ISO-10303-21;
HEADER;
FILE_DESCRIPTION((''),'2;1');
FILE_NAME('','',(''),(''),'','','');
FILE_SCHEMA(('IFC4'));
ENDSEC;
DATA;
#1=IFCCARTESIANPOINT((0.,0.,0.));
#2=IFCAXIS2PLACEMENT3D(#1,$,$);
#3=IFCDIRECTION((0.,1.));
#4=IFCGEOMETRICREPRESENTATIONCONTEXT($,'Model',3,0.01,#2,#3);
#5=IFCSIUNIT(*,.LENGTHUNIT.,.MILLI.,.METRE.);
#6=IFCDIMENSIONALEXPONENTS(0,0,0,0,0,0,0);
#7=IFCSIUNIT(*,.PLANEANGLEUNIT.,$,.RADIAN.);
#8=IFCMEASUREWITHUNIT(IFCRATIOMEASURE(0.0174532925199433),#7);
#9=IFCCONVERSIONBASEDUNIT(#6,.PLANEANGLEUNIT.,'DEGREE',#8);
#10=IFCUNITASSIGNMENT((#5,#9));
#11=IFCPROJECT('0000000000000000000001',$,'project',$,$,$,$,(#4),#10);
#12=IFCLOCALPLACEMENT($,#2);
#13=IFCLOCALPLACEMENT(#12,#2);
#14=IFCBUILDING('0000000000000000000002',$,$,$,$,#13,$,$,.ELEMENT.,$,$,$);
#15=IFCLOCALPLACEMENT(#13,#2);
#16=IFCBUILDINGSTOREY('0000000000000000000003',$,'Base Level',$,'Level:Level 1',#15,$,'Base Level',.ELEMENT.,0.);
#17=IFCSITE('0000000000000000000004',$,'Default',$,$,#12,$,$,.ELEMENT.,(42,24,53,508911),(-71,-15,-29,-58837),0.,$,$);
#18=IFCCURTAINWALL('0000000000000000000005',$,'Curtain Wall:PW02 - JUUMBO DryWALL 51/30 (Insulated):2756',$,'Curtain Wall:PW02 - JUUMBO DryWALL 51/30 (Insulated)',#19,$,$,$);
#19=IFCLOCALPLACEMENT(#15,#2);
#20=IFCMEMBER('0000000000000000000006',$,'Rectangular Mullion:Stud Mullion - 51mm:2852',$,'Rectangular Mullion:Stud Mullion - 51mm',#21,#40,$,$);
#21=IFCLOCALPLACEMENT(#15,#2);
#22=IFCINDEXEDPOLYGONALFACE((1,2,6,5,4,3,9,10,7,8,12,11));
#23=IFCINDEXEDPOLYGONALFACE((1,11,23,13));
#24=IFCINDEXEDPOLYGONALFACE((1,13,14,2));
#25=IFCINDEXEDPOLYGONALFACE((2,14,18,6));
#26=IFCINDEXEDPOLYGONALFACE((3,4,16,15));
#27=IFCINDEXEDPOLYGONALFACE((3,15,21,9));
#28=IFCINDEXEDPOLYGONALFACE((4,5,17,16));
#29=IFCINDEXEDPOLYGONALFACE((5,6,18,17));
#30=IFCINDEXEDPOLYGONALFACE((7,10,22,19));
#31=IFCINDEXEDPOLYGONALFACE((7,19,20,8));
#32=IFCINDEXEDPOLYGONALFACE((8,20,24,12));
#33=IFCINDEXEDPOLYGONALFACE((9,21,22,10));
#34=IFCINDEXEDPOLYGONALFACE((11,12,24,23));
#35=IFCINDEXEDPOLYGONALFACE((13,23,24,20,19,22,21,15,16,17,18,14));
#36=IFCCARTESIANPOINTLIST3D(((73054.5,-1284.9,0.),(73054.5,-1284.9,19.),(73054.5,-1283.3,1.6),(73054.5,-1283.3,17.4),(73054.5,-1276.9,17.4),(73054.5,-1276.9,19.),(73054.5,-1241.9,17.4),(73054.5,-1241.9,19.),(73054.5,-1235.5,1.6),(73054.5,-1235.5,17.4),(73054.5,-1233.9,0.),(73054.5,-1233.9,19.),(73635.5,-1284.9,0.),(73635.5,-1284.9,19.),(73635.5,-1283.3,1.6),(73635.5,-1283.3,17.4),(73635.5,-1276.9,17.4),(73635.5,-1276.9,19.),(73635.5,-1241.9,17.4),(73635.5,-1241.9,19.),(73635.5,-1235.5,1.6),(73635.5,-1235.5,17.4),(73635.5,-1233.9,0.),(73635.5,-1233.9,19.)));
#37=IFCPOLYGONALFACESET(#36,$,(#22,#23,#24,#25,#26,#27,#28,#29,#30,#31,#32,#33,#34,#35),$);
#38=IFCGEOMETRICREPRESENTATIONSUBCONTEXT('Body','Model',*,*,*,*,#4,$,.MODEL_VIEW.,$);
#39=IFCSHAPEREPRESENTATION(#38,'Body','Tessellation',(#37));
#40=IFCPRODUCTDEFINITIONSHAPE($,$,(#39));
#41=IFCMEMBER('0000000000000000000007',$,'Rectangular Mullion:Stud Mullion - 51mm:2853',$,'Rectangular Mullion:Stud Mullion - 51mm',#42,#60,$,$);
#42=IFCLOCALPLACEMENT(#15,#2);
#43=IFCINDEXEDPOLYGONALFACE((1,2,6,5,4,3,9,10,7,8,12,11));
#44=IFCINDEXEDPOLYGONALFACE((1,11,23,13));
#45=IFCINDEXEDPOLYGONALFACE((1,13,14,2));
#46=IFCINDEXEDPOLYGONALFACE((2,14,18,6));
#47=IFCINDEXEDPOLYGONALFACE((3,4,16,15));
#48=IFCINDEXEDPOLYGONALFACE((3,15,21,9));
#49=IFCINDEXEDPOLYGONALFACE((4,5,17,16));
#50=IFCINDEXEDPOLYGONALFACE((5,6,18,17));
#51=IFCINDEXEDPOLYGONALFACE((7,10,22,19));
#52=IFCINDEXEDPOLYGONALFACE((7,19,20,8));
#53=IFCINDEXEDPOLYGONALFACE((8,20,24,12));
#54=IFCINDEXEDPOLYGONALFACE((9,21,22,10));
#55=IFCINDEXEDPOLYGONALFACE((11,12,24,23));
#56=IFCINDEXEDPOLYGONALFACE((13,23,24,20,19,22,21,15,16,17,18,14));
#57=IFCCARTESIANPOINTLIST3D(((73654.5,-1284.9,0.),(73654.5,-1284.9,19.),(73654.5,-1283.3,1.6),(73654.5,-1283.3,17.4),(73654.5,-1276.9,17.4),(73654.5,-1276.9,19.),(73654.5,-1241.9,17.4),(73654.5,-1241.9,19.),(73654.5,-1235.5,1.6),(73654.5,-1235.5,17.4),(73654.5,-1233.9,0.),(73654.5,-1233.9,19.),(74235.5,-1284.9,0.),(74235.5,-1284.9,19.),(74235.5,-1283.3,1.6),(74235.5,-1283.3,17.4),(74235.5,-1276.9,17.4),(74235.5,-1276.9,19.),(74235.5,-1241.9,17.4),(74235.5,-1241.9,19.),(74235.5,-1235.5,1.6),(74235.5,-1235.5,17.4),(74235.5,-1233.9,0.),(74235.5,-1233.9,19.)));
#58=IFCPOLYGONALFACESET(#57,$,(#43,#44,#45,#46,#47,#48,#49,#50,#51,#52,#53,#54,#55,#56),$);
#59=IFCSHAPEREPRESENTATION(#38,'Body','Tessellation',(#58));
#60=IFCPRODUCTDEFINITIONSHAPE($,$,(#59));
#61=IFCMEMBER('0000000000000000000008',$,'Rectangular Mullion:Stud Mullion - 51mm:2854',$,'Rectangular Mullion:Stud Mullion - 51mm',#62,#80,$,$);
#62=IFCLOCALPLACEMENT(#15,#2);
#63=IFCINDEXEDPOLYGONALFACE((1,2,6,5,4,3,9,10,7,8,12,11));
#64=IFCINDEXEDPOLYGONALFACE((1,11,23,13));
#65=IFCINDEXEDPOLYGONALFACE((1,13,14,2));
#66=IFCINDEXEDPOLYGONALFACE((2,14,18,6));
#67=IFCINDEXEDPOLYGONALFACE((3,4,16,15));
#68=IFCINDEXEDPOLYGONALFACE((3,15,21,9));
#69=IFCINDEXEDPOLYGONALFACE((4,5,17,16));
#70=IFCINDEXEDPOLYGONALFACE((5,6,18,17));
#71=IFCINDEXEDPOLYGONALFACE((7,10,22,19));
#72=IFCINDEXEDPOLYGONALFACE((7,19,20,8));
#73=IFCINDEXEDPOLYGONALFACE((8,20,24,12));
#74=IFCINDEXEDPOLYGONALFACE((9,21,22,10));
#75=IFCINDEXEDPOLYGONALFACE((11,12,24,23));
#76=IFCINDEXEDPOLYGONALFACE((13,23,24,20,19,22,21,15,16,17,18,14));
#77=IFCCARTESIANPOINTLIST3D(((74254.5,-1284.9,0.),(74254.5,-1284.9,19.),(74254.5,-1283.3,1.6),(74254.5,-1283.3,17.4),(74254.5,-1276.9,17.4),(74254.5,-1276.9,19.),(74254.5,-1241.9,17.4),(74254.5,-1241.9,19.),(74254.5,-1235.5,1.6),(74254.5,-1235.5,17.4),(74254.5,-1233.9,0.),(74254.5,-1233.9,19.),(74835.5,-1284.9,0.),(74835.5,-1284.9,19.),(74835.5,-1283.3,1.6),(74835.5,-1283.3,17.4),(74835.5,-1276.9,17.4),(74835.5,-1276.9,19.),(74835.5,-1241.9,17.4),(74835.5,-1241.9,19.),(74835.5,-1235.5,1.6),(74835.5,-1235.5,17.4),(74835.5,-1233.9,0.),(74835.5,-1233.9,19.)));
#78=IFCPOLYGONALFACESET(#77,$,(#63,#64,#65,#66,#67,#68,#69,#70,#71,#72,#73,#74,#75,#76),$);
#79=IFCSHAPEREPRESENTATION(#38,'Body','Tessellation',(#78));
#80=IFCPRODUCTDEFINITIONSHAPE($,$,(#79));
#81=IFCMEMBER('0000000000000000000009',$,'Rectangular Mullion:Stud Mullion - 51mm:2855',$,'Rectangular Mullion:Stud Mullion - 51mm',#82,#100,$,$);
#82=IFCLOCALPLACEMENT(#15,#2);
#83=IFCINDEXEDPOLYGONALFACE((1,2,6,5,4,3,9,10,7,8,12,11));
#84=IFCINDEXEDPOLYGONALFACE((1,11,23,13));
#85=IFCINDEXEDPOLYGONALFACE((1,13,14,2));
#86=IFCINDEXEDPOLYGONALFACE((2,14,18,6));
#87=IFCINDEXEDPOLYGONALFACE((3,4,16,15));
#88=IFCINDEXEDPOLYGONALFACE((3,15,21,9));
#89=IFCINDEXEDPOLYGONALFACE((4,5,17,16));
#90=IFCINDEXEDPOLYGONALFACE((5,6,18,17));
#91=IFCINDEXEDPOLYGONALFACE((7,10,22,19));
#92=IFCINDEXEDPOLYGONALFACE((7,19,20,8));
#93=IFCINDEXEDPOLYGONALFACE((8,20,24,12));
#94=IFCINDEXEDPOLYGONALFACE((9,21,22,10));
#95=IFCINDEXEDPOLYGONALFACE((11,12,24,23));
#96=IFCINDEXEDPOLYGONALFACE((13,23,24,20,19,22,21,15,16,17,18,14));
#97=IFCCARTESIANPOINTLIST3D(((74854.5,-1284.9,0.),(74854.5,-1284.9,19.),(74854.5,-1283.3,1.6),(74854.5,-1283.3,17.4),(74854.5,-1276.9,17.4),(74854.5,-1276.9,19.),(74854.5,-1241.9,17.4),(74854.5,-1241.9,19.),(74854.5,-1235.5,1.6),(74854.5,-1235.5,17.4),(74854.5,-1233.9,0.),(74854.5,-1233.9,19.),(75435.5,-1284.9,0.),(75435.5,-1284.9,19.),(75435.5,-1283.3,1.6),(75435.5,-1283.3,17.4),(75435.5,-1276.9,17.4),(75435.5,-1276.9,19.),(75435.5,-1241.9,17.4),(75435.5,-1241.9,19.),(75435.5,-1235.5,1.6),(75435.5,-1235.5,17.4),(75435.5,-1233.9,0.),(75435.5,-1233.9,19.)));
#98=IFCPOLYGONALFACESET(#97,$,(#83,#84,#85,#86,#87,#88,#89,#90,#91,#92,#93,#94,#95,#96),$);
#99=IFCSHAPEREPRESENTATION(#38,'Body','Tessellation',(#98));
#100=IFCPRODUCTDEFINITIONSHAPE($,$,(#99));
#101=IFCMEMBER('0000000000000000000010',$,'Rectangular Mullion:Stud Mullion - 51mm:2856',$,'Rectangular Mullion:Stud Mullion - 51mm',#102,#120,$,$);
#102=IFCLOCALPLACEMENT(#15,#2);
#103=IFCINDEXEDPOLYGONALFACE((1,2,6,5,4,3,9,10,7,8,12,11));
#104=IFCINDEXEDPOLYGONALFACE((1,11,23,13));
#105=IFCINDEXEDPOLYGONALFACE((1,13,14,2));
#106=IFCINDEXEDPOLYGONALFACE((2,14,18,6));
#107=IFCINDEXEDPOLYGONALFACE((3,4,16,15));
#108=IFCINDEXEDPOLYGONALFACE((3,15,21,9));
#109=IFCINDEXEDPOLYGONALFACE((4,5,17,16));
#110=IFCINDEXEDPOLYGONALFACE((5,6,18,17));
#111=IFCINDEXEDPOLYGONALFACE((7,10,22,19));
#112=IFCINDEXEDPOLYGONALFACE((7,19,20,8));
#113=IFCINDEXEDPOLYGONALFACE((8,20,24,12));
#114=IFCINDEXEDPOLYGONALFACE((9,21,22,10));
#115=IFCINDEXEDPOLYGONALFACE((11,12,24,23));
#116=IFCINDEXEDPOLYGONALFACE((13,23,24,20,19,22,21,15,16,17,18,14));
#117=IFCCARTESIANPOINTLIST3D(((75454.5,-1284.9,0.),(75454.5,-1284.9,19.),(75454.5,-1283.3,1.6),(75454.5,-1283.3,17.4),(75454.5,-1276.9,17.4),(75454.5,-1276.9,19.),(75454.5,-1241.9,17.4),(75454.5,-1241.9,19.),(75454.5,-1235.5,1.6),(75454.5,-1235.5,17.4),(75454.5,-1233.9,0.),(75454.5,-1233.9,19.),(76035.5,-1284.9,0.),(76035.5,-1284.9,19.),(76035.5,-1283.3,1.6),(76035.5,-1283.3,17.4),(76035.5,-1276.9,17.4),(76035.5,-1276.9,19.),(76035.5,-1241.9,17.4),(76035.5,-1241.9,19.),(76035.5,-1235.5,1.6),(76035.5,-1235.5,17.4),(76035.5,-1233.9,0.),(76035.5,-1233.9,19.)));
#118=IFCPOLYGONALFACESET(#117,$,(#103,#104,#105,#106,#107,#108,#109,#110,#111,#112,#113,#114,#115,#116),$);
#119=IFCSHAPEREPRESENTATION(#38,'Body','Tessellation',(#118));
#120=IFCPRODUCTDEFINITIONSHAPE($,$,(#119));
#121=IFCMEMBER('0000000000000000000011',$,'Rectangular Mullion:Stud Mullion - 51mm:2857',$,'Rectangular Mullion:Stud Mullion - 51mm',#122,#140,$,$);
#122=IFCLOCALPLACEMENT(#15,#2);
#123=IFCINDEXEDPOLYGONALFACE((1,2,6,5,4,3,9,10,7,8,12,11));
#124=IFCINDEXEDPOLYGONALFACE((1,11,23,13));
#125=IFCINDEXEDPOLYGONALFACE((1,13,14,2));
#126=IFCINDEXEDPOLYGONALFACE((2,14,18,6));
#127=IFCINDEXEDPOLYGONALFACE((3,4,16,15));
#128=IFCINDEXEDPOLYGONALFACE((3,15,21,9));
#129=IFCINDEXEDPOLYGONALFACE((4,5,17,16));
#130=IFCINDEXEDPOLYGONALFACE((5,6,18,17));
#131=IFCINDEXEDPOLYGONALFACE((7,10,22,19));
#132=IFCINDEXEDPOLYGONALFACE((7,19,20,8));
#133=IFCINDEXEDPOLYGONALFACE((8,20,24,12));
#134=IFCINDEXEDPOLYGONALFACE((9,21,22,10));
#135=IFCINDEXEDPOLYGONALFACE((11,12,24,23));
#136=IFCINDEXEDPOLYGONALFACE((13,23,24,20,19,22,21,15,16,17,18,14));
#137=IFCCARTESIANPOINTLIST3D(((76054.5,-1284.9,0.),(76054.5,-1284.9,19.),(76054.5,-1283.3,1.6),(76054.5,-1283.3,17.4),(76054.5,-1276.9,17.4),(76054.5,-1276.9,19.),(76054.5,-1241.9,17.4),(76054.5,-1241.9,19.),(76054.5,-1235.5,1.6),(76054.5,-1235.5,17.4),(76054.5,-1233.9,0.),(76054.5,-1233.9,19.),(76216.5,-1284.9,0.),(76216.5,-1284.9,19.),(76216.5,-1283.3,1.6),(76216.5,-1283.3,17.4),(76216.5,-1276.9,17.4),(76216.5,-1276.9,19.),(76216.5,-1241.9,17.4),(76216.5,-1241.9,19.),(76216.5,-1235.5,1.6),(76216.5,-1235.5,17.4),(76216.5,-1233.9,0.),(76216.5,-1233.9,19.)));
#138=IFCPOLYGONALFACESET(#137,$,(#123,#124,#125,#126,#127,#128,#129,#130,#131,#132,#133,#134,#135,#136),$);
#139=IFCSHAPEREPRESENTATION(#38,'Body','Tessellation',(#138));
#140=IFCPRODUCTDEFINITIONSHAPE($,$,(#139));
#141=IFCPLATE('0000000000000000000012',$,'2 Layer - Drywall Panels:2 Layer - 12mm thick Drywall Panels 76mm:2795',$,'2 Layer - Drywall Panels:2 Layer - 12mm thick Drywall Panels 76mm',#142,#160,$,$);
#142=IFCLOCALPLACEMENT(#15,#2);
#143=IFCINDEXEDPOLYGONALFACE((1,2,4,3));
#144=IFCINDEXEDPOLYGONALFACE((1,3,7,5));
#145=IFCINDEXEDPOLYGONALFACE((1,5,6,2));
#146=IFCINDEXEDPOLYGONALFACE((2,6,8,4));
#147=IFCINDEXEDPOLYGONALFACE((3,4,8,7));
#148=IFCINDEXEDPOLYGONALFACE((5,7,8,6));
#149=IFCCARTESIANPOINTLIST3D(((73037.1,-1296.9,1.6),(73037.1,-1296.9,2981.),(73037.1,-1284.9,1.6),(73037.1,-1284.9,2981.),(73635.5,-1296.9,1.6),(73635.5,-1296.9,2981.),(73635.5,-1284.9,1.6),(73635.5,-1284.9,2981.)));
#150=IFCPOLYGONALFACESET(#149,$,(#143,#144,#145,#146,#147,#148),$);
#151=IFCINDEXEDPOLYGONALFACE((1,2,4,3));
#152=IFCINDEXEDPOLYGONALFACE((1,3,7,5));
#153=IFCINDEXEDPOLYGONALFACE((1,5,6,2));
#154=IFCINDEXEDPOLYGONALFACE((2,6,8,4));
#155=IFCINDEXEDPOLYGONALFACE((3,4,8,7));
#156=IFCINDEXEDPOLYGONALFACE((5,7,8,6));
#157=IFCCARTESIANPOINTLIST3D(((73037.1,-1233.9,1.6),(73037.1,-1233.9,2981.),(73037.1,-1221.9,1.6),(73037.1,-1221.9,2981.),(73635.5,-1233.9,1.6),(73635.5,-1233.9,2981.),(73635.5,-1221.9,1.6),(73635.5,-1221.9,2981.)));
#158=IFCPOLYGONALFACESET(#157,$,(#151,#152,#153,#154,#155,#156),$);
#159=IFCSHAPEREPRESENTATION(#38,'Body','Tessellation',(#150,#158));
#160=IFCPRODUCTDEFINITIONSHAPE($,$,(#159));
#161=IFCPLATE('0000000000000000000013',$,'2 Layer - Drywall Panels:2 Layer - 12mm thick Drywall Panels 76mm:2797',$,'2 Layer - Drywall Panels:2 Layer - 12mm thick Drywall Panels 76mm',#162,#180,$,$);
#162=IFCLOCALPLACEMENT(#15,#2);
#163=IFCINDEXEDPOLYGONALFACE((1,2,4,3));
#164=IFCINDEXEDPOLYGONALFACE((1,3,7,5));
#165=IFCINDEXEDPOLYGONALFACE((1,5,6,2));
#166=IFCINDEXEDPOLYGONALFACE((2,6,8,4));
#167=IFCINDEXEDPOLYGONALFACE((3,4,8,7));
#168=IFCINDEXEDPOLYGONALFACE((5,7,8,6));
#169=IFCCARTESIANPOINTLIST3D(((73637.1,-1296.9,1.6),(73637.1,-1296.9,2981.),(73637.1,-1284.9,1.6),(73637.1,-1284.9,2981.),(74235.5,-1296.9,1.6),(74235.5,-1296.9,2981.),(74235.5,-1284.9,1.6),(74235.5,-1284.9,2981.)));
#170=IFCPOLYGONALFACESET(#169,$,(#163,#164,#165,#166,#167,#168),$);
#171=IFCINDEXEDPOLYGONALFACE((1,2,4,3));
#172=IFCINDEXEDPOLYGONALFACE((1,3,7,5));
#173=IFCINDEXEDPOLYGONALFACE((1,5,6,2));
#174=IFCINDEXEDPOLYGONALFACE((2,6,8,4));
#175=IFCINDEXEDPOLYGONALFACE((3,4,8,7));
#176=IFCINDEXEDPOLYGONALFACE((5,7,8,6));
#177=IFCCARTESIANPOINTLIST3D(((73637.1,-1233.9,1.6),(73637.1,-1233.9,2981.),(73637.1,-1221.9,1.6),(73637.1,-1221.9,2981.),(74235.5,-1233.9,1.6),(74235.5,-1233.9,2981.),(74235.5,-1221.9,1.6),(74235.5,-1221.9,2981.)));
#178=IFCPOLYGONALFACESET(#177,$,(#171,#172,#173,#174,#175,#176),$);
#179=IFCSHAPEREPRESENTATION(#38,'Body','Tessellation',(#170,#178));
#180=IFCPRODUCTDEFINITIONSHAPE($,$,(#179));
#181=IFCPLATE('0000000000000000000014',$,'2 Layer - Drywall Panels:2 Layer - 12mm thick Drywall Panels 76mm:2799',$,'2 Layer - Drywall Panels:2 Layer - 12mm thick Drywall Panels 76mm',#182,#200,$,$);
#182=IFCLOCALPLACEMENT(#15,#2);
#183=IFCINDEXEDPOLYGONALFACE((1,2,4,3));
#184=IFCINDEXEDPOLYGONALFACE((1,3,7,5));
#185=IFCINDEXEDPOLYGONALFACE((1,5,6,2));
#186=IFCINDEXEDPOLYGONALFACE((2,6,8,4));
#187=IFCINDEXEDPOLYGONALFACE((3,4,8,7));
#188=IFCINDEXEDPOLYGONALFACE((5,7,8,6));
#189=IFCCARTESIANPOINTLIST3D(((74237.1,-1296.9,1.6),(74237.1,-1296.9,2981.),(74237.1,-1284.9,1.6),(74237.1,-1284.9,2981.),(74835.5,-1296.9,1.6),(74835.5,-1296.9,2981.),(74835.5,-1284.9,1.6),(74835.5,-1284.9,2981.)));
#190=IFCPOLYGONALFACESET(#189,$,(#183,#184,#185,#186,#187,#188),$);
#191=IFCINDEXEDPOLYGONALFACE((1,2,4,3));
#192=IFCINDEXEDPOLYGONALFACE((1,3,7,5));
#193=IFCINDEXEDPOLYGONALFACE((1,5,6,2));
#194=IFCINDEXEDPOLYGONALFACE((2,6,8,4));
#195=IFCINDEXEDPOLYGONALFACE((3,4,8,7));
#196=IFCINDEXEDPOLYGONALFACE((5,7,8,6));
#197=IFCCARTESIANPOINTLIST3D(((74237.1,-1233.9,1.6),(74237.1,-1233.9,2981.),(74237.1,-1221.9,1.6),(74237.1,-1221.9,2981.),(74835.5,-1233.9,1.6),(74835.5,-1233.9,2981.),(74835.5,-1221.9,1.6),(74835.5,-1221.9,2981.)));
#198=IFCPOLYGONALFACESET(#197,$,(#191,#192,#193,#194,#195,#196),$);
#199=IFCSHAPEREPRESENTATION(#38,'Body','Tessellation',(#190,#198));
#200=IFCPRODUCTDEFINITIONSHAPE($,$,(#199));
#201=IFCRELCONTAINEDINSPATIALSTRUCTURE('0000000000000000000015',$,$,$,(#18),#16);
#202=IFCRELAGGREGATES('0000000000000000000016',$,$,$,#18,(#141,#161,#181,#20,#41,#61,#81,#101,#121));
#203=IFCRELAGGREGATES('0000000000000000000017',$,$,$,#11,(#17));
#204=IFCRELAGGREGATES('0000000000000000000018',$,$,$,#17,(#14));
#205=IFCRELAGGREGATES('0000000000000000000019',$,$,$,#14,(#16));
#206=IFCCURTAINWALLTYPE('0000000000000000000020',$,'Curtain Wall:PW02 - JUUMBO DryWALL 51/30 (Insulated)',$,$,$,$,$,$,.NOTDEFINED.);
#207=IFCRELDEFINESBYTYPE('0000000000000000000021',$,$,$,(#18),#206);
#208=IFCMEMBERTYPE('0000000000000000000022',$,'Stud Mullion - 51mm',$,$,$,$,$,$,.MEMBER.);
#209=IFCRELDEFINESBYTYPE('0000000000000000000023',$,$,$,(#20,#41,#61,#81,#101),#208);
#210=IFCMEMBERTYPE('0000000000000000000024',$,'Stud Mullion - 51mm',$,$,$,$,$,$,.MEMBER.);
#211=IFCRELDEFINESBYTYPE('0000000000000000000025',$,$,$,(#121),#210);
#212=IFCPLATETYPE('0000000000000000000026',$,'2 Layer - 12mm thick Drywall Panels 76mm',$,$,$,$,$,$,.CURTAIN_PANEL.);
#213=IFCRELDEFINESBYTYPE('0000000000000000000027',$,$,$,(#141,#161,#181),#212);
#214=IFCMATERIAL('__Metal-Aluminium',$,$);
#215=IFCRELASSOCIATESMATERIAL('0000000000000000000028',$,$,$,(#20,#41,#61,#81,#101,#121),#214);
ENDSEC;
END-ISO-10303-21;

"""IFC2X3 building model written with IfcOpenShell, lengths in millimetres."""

from ifc_helpers import new_model, entity, si_unit, converted_unit, direction, frame, frame_2d, origin, origin_2d_with_axis, place, context, subcontext, project, spatial, polyline, rectangle, outline, extrude, source, transform, mapped, material, type_object, type_shapes, element, aggregate, save


model = new_model("IFC2X3")

# Units and contexts
model_context = context("Model", 3, precision=0.01, world=origin(), true_north=direction((0.0, 1.0)))
body_context = subcontext(model_context, "Body", "Model", "MODEL_VIEW")
ifc_project = project(units=[si_unit("LENGTHUNIT", "METRE", prefix="MILLI"), converted_unit("PLANEANGLEUNIT", "DEGREE", entity("IfcRatioMeasure", 0.0174532925199433), si_unit("PLANEANGLEUNIT", "RADIAN"), dimensions=[0, 0, 0, 0, 0, 0, 0])], contexts=[model_context])

# Site, building, storey
site_placement = place(None, origin())
site = spatial("IfcSite", under=ifc_project, at=site_placement, Name="Default", CompositionType="ELEMENT", RefLatitude=(42, 24, 53, 508911), RefLongitude=(-71, -15, -29, -58837), RefElevation=0.0)
building_placement = place(site_placement, origin())
building = spatial("IfcBuilding", under=site, at=building_placement, CompositionType="ELEMENT")
storey_placement = place(building_placement, origin())
storey = spatial("IfcBuildingStorey", under=building, at=storey_placement, Name="Base Level", ObjectType="Level:Level 1", LongName="Base Level", CompositionType="ELEMENT", Elevation=0.0)

# Curtain wall, members, plates
curtain_wall_type = type_object("IfcCurtainWallType", Name="Curtain Wall:PW02 - JUUMBO DryWALL 51/30 (Insulated)", PredefinedType="NOTDEFINED")
curtain_wall_placement = place(building_placement, origin())
curtain_wall = element("IfcCurtainWall", 1, at=curtain_wall_placement, inside=storey, type_object=curtain_wall_type, Name="Curtain Wall:PW02 - JUUMBO DryWALL 51/30 (Insulated):2756", ObjectType="Curtain Wall:PW02 - JUUMBO DryWALL 51/30 (Insulated)")
ifc_material = material(Name="__Metal-Aluminium")
member_type_1 = type_object("IfcMemberType", Name="Stud Mullion - 51mm", PredefinedType="MEMBER")
shared_shape_1 = source(origin(), body_context, "Body", "SweptSolid", [
    extrude(outline(polyline([(17.5, -6.6), (25.5, -6.6), (25.5, 12.4), (-25.5, 12.4), (-25.5, -6.6), (-17.5, -6.6), (-17.5, -5.0), (-23.9, -5.0), (-23.9, 10.8), (23.9, 10.8), (23.9, -5.0), (17.5, -5.0), (17.5, -6.6)])), frame((-12.4, 0.0, -581.0), z_axis=(0.0, 0.0, 1.0), x_axis=(0.0, -1.0, 0.0)), (0.0, 0.0, 1.0), 581.0),
])
type_shapes(member_type_1, [shared_shape_1])
member_1_placement = place(building_placement, frame((73054.5, -1259.4, 0.0), z_axis=(-1.0, 0.0, 0.0), x_axis=(0.0, 0.0, -1.0)))
member_1 = element("IfcMember", 2, at=member_1_placement, type_object=member_type_1, material=ifc_material, Name="Rectangular Mullion:Stud Mullion - 51mm:2852", ObjectType="Rectangular Mullion:Stud Mullion - 51mm", context=body_context, shape_type="MappedRepresentation", body=[
    mapped(shared_shape_1, transform((0.0, 0.0, 0.0), scale=1.0)),
])
member_2_placement = place(building_placement, frame((73654.5, -1259.4, 0.0), z_axis=(-1.0, 0.0, 0.0), x_axis=(0.0, 0.0, -1.0)))
member_2 = element("IfcMember", 3, at=member_2_placement, type_object=member_type_1, material=ifc_material, Name="Rectangular Mullion:Stud Mullion - 51mm:2853", ObjectType="Rectangular Mullion:Stud Mullion - 51mm", context=body_context, shape_type="MappedRepresentation", body=[
    mapped(shared_shape_1, transform((0.0, 0.0, 0.0), scale=1.0)),
])
member_3_placement = place(building_placement, frame((74254.5, -1259.4, 0.0), z_axis=(-1.0, 0.0, 0.0), x_axis=(0.0, 0.0, -1.0)))
member_3 = element("IfcMember", 4, at=member_3_placement, type_object=member_type_1, material=ifc_material, Name="Rectangular Mullion:Stud Mullion - 51mm:2854", ObjectType="Rectangular Mullion:Stud Mullion - 51mm", context=body_context, shape_type="MappedRepresentation", body=[
    mapped(shared_shape_1, transform((0.0, 0.0, 0.0), scale=1.0)),
])
member_4_placement = place(building_placement, frame((74854.5, -1259.4, 0.0), z_axis=(-1.0, 0.0, 0.0), x_axis=(0.0, 0.0, -1.0)))
member_4 = element("IfcMember", 5, at=member_4_placement, type_object=member_type_1, material=ifc_material, Name="Rectangular Mullion:Stud Mullion - 51mm:2855", ObjectType="Rectangular Mullion:Stud Mullion - 51mm", context=body_context, shape_type="MappedRepresentation", body=[
    mapped(shared_shape_1, transform((0.0, 0.0, 0.0), scale=1.0)),
])
member_5_placement = place(building_placement, frame((75454.5, -1259.4, 0.0), z_axis=(-1.0, 0.0, 0.0), x_axis=(0.0, 0.0, -1.0)))
member_5 = element("IfcMember", 6, at=member_5_placement, type_object=member_type_1, material=ifc_material, Name="Rectangular Mullion:Stud Mullion - 51mm:2856", ObjectType="Rectangular Mullion:Stud Mullion - 51mm", context=body_context, shape_type="MappedRepresentation", body=[
    mapped(shared_shape_1, transform((0.0, 0.0, 0.0), scale=1.0)),
])
member_type_2 = type_object("IfcMemberType", Name="Stud Mullion - 51mm", PredefinedType="MEMBER")
shared_shape_2 = source(origin(), body_context, "Body", "SweptSolid", [
    extrude(outline(polyline([(17.5, -6.6), (25.5, -6.6), (25.5, 12.4), (-25.5, 12.4), (-25.5, -6.6), (-17.5, -6.6), (-17.5, -5.0), (-23.9, -5.0), (-23.9, 10.8), (23.9, 10.8), (23.9, -5.0), (17.5, -5.0), (17.5, -6.6)])), frame((-12.4, 0.0, -162.0), z_axis=(0.0, 0.0, 1.0), x_axis=(0.0, -1.0, 0.0)), (0.0, 0.0, 1.0), 162.0),
])
type_shapes(member_type_2, [shared_shape_2])
member_6_placement = place(building_placement, frame((76054.5, -1259.4, 0.0), z_axis=(-1.0, 0.0, 0.0), x_axis=(0.0, 0.0, -1.0)))
member_6 = element("IfcMember", 7, at=member_6_placement, type_object=member_type_2, material=ifc_material, Name="Rectangular Mullion:Stud Mullion - 51mm:2857", ObjectType="Rectangular Mullion:Stud Mullion - 51mm", context=body_context, shape_type="MappedRepresentation", body=[
    mapped(shared_shape_2, transform((0.0, 0.0, 0.0), scale=1.0)),
])
plate_type_1 = type_object("IfcPlateType", Name="2 Layer - 12mm thick Drywall Panels 76mm", PredefinedType="CURTAIN_PANEL")
shared_shape_3 = source(origin(), body_context, "Body", "SweptSolid", [
    extrude(rectangle(XDim=598.4, YDim=12.0, at=origin_2d_with_axis()), frame((0.0, -31.5, 0.0), z_axis=(0.0, 0.0, 1.0), x_axis=(-1.0, 0.0, 0.0)), (0.0, 0.0, 1.0), 2979.4),
    extrude(rectangle(XDim=12.0, YDim=598.4, at=frame_2d((0.0, 0.0), x_axis=(1.0, 0.0))), frame((0.0, 31.5, 0.0), z_axis=(0.0, 0.0, 1.0), x_axis=(0.0, 1.0, 0.0)), (0.0, 0.0, 1.0), 2979.4),
])
type_shapes(plate_type_1, [shared_shape_3])
plate_1_placement = place(curtain_wall_placement, frame((73336.3, -1259.4, 1.6)))
plate_1 = element("IfcPlate", 8, at=plate_1_placement, type_object=plate_type_1, Name="2 Layer - Drywall Panels:2 Layer - 12mm thick Drywall Panels 76mm:2795", ObjectType="2 Layer - Drywall Panels:2 Layer - 12mm thick Drywall Panels 76mm", context=body_context, shape_type="MappedRepresentation", body=[
    mapped(shared_shape_3, transform((0.0, 0.0, 0.0), scale=1.0)),
])
plate_2_placement = place(curtain_wall_placement, frame((73936.3, -1259.4, 1.6)))
plate_2 = element("IfcPlate", 9, at=plate_2_placement, type_object=plate_type_1, Name="2 Layer - Drywall Panels:2 Layer - 12mm thick Drywall Panels 76mm:2797", ObjectType="2 Layer - Drywall Panels:2 Layer - 12mm thick Drywall Panels 76mm", context=body_context, shape_type="MappedRepresentation", body=[
    mapped(shared_shape_3, transform((0.0, 0.0, 0.0), scale=1.0)),
])
plate_3_placement = place(curtain_wall_placement, frame((74536.3, -1259.4, 1.6)))
plate_3 = element("IfcPlate", 10, at=plate_3_placement, type_object=plate_type_1, Name="2 Layer - Drywall Panels:2 Layer - 12mm thick Drywall Panels 76mm:2799", ObjectType="2 Layer - Drywall Panels:2 Layer - 12mm thick Drywall Panels 76mm", context=body_context, shape_type="MappedRepresentation", body=[
    mapped(shared_shape_3, transform((0.0, 0.0, 0.0), scale=1.0)),
])
aggregate(curtain_wall, [plate_1, plate_2, plate_3, member_1, member_2, member_3, member_4, member_5, member_6])

save(model, "model.ifc")
